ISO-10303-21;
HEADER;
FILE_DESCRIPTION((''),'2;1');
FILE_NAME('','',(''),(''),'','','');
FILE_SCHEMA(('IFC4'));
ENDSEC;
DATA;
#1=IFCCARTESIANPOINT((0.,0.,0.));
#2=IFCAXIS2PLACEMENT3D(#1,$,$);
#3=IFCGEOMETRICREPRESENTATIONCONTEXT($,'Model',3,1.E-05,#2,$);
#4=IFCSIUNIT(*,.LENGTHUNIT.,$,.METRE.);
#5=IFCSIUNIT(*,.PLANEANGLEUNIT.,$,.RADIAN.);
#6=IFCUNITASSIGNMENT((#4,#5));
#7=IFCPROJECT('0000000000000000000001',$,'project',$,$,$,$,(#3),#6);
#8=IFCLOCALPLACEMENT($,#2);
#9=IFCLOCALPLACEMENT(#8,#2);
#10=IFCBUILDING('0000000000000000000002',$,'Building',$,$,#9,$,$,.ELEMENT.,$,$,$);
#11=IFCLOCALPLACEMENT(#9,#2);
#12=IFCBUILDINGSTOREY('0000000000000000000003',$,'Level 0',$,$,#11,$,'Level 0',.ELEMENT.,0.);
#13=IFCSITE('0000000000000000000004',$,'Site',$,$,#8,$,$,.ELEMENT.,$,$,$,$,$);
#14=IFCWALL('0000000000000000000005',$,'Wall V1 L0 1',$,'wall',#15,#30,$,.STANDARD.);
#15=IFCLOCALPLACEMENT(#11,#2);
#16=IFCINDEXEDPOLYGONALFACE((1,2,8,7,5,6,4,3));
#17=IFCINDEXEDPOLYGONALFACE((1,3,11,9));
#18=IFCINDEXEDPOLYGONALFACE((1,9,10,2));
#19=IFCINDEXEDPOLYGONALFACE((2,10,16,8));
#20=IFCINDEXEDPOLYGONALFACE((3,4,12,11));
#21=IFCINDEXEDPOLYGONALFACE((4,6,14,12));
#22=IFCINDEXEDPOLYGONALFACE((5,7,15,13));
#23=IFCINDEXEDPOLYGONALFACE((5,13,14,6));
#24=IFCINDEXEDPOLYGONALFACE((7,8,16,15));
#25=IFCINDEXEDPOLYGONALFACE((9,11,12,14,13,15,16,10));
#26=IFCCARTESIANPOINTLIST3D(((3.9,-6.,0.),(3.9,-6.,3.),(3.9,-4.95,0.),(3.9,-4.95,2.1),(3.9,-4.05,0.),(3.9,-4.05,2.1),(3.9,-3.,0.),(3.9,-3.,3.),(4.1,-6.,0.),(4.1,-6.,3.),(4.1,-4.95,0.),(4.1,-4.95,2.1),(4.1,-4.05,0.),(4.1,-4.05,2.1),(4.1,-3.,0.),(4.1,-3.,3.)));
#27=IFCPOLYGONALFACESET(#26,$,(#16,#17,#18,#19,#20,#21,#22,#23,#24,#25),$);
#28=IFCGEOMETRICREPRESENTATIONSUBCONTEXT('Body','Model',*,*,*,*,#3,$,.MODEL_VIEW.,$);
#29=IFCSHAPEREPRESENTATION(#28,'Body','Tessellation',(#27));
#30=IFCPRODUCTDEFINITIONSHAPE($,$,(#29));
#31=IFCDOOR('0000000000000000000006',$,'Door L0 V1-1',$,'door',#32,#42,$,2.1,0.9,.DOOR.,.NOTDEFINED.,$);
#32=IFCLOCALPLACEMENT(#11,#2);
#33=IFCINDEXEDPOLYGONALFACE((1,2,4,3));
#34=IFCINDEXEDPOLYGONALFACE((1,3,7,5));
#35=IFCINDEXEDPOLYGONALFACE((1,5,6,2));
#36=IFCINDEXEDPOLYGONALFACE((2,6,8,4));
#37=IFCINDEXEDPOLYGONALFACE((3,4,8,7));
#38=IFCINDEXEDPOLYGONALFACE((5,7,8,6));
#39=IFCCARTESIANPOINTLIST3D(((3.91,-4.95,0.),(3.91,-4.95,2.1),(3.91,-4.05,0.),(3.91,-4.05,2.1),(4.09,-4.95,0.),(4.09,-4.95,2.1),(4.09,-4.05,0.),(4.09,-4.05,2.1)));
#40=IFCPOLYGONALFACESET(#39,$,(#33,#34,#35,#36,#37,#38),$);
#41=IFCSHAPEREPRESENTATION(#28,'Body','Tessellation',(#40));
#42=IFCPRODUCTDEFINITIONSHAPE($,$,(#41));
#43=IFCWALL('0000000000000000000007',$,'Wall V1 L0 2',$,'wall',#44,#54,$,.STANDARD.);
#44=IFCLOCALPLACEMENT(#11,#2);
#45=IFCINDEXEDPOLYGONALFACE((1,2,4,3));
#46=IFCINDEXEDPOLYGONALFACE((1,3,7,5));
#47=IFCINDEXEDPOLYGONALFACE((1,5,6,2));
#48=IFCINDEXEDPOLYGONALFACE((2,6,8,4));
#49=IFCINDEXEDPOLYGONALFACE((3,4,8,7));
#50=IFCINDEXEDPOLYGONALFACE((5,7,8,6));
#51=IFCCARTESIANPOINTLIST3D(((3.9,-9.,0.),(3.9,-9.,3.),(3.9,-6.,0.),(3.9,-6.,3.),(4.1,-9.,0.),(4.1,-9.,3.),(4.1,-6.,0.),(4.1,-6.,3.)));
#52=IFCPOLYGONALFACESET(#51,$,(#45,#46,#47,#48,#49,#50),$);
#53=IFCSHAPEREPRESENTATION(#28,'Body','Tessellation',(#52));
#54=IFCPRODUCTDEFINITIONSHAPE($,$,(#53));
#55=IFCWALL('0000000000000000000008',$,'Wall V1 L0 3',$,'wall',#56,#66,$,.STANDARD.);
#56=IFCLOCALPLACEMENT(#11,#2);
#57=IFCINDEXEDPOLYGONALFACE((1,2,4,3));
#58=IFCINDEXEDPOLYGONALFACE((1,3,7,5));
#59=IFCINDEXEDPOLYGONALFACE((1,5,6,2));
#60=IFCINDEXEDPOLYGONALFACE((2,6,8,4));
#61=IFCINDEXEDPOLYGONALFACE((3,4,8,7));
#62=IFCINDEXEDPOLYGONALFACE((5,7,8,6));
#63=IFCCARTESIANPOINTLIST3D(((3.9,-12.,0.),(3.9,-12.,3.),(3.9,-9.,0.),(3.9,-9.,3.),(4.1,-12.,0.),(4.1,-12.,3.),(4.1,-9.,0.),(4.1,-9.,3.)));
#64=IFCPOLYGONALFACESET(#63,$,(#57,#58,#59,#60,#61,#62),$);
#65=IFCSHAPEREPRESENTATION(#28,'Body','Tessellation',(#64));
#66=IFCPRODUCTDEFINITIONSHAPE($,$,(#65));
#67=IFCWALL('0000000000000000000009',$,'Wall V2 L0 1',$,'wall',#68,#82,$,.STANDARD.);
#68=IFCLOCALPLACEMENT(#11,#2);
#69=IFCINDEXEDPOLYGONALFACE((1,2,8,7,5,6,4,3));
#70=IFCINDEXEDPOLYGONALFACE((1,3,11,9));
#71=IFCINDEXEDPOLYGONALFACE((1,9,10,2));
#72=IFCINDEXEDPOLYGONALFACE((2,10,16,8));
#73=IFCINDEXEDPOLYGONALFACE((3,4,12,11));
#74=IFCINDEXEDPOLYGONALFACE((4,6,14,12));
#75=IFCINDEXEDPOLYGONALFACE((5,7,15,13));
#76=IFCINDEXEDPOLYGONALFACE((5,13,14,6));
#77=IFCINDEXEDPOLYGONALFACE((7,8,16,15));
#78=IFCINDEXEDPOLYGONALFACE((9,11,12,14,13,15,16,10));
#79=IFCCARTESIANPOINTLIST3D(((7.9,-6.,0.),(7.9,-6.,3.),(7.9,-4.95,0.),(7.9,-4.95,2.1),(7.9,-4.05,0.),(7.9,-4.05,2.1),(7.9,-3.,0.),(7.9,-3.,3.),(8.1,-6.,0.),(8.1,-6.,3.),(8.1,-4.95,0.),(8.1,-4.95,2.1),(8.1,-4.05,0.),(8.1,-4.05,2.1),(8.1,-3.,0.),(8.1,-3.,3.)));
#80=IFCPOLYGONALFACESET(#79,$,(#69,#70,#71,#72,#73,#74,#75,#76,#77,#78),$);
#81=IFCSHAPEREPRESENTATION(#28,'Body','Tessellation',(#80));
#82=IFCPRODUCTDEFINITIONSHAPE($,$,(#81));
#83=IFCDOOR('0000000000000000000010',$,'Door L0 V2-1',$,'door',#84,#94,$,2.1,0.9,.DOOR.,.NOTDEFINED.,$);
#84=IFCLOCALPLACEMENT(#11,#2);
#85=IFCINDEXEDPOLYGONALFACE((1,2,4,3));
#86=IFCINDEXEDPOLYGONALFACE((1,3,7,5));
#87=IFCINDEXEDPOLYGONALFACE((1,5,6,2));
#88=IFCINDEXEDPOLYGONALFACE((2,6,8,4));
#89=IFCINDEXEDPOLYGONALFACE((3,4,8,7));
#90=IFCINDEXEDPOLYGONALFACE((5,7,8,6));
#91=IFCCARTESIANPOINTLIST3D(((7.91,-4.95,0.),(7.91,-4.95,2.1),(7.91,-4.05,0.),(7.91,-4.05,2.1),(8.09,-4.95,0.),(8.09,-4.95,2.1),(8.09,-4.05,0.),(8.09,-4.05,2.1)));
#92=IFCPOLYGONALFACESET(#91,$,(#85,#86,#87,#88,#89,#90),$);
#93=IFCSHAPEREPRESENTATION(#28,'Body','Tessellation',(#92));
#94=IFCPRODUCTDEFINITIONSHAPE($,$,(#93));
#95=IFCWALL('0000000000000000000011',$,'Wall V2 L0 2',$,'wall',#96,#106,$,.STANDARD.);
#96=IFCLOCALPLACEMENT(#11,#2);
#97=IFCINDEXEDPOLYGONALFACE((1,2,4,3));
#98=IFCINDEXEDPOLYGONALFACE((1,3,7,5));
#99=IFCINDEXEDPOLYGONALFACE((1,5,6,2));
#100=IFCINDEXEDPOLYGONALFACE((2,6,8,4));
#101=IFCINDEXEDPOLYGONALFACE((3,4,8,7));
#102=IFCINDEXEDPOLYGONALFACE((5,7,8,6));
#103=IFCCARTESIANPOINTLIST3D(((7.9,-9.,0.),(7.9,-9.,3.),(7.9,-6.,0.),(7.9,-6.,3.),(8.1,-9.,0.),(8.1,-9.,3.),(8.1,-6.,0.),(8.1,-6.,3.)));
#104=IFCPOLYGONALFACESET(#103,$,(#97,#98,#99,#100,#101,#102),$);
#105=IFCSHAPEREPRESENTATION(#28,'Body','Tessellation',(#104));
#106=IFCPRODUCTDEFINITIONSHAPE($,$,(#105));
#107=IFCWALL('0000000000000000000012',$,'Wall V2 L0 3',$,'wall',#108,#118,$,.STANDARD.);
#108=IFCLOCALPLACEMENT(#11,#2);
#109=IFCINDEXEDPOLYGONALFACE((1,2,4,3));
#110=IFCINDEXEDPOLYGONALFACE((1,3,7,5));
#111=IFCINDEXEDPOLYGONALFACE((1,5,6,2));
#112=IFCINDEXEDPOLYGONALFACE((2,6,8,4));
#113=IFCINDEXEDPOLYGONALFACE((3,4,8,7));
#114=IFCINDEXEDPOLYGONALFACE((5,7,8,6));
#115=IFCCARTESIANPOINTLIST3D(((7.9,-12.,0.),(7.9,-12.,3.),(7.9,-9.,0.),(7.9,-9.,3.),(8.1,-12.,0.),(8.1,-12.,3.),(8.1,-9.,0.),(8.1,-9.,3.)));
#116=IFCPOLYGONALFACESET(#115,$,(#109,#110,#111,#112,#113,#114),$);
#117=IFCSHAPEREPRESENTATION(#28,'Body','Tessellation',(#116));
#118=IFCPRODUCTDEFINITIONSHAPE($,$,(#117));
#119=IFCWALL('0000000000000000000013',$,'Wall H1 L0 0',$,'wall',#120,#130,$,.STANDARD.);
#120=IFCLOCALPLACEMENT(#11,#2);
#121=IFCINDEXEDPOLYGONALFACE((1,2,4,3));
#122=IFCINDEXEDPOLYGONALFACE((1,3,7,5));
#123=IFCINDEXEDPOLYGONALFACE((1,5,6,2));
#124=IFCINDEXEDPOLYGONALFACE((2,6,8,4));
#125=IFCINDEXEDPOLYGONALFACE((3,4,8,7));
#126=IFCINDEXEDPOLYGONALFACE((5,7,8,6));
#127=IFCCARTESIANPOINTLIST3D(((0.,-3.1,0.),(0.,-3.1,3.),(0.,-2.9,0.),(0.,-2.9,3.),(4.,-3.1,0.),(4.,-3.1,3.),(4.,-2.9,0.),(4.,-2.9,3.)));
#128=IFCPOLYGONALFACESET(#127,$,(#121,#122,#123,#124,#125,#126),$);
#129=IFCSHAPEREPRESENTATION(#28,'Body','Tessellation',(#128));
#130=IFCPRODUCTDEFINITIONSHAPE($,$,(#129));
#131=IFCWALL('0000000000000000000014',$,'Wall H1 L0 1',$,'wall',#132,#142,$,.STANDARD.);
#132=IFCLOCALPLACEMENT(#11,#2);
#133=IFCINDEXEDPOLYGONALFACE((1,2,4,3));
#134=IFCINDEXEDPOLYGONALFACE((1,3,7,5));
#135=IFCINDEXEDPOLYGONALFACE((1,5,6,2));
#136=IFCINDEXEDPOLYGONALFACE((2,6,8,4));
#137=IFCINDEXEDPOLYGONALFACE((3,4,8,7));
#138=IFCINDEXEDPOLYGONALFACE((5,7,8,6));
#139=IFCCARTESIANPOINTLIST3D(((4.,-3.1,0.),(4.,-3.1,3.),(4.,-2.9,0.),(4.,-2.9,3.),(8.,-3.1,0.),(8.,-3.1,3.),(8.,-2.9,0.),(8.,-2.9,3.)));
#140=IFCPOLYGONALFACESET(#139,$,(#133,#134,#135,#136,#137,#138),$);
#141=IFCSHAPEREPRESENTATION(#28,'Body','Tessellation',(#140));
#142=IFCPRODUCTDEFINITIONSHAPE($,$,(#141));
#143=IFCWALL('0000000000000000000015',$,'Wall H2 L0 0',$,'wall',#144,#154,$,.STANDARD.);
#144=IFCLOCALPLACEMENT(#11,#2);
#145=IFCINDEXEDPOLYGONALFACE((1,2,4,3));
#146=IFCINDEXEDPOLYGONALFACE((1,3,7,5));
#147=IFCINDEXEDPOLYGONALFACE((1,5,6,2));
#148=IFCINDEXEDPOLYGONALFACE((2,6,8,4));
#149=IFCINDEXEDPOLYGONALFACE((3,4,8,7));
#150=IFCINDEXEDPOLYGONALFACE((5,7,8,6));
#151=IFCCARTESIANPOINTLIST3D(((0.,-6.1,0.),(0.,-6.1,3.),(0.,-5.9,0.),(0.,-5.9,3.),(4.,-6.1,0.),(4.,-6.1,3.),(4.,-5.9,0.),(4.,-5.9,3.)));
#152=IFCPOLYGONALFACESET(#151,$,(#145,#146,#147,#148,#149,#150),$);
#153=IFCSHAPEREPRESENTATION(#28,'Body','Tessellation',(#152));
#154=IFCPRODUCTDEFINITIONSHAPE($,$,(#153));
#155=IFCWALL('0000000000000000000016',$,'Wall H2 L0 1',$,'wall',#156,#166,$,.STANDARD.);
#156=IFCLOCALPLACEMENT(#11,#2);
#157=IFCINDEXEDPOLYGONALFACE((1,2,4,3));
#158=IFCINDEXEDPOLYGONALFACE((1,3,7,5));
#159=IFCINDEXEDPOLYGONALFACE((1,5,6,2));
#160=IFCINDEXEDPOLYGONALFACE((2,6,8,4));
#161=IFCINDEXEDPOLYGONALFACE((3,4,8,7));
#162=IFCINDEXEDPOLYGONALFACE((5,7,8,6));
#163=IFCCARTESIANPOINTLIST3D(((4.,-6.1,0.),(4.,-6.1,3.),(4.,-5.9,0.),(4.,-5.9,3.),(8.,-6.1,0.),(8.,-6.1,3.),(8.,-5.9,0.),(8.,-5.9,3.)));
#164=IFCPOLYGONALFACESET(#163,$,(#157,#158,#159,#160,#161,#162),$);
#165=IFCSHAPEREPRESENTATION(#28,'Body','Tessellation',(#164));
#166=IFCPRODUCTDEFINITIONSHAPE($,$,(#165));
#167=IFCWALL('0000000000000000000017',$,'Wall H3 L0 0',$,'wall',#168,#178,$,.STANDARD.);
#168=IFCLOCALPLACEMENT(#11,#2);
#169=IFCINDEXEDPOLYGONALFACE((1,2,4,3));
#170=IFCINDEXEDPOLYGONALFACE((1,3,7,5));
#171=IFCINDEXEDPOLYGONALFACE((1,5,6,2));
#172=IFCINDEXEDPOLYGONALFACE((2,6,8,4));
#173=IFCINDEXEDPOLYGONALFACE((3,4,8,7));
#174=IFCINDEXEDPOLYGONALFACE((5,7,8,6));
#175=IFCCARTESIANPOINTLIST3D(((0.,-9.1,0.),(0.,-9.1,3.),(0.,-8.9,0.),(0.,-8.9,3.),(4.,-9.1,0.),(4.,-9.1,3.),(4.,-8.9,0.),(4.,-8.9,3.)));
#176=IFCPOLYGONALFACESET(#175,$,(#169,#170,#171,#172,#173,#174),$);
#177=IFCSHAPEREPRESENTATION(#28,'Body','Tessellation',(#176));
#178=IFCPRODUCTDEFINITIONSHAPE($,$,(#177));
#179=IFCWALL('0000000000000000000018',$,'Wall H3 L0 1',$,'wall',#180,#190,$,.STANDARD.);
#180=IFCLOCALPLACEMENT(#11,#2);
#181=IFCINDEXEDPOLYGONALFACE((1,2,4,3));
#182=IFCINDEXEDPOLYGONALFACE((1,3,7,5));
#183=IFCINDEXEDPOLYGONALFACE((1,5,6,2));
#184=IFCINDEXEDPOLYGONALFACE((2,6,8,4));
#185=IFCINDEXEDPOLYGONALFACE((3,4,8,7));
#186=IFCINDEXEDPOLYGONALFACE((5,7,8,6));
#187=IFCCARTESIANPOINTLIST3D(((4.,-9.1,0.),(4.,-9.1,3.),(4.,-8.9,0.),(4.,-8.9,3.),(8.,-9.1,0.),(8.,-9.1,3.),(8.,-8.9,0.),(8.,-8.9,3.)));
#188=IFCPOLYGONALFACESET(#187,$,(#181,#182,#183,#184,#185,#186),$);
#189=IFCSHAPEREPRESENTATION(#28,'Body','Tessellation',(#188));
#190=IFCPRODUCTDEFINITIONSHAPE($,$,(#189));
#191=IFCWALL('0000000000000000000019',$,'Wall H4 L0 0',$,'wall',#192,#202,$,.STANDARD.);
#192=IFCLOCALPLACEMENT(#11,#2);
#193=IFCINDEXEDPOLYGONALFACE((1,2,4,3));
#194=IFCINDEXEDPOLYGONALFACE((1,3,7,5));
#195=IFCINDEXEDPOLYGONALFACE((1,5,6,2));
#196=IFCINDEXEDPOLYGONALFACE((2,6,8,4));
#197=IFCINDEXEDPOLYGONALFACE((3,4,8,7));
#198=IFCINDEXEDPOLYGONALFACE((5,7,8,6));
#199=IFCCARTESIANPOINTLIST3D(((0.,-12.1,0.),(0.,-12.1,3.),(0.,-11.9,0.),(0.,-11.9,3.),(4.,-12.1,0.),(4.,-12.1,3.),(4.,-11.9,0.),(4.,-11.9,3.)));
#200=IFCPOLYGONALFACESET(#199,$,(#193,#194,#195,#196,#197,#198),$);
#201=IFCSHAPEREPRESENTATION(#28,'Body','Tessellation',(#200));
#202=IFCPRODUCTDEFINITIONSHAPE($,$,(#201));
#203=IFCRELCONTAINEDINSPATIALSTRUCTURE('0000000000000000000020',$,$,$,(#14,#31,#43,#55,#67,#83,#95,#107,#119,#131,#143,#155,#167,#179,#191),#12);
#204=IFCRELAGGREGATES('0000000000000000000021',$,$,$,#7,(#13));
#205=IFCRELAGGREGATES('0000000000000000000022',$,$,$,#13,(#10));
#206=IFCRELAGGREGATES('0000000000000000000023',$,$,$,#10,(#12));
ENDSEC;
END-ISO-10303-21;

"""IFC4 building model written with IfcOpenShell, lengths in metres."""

from ifc_helpers import new_model, si_unit, frame, frame_2d, origin, origin_2d, place, context, subcontext, project, spatial, rectangle, extrude, element, fill, save


model = new_model("IFC4")

# Units and contexts
model_context = context("Model", 3, precision=1e-05, world=origin())
body_context = subcontext(model_context, "Body", "Model", "MODEL_VIEW")
ifc_project = project(units=[si_unit("LENGTHUNIT", "METRE"), si_unit("PLANEANGLEUNIT", "RADIAN")], contexts=[model_context])

# Site, building, storey
site_placement = place(None, origin())
site = spatial("IfcSite", under=ifc_project, at=site_placement, Name="Site", CompositionType="ELEMENT")
building_placement = place(site_placement, origin())
building = spatial("IfcBuilding", under=site, at=building_placement, Name="Building", CompositionType="ELEMENT")
storey_placement = place(building_placement, origin())
storey = spatial("IfcBuildingStorey", under=building, at=storey_placement, Name="Level 0", LongName="Level 0", CompositionType="ELEMENT", Elevation=0.0)

# Wall, opening, door
wall_1_placement = place(storey_placement, frame((4.0, -3.0, 0.0), z_axis=(0.0, 0.0, 1.0), x_axis=(0.0, -1.0, 0.0)))
wall_1 = element("IfcWall", 1, at=wall_1_placement, inside=storey, Name="Wall V1 L0 1", ObjectType="wall", PredefinedType="STANDARD", context=body_context, shape_type="SweptSolid", body=[
    extrude(rectangle(XDim=3.0, YDim=0.2, at=frame_2d((1.5, 0.0))), origin(), (0.0, 0.0, 1.0), 3.0),
])
opening_1_placement = place(storey_placement, frame((4.0, -4.5, 0.0), z_axis=(0.0, 0.0, 1.0), x_axis=(0.0, -1.0, 0.0)))
opening_1 = element("IfcOpeningElement", 2, at=opening_1_placement, cuts=wall_1, ObjectType="Opening", PredefinedType="OPENING", context=body_context, shape_type="SweptSolid", body=[
    extrude(rectangle(XDim=0.9, YDim=0.22, at=origin_2d()), origin(), (0.0, 0.0, 1.0), 2.1),
])
door_1_placement = place(storey_placement, frame((4.0, -4.5, 0.0), z_axis=(0.0, 0.0, 1.0), x_axis=(0.0, -1.0, 0.0)))
door_1 = element("IfcDoor", 3, at=door_1_placement, inside=storey, Name="Door L0 V1-1", ObjectType="door", OperationType="NOTDEFINED", OverallHeight=2.1, OverallWidth=0.9, PredefinedType="DOOR", context=body_context, shape_type="SweptSolid", body=[
    extrude(rectangle(XDim=0.9, YDim=0.18, at=origin_2d()), origin(), (0.0, 0.0, 1.0), 2.1),
])
fill(opening_1, door_1)

# Walls
for number, where, z_axis, x_axis, name in (
    (4, (4.0, -6.0, 0.0), (0.0, 0.0, 1.0), (0.0, -1.0, 0.0), "Wall V1 L0 2"),
    (5, (4.0, -9.0, 0.0), (0.0, 0.0, 1.0), (0.0, -1.0, 0.0), "Wall V1 L0 3"),
):
    element("IfcWall", number, at=place(storey_placement, frame(where, z_axis=z_axis, x_axis=x_axis)), inside=storey, Name=name, ObjectType="wall", PredefinedType="STANDARD", context=body_context, shape_type="SweptSolid", body=[
        extrude(rectangle(XDim=3.0, YDim=0.2, at=frame_2d((1.5, 0.0))), origin(), (0.0, 0.0, 1.0), 3.0),
    ])

# Wall, opening, door
wall_2_placement = place(storey_placement, frame((8.0, -3.0, 0.0), z_axis=(0.0, 0.0, 1.0), x_axis=(0.0, -1.0, 0.0)))
wall_2 = element("IfcWall", 6, at=wall_2_placement, inside=storey, Name="Wall V2 L0 1", ObjectType="wall", PredefinedType="STANDARD", context=body_context, shape_type="SweptSolid", body=[
    extrude(rectangle(XDim=3.0, YDim=0.2, at=frame_2d((1.5, 0.0))), origin(), (0.0, 0.0, 1.0), 3.0),
])
opening_2_placement = place(storey_placement, frame((8.0, -4.5, 0.0), z_axis=(0.0, 0.0, 1.0), x_axis=(0.0, -1.0, 0.0)))
opening_2 = element("IfcOpeningElement", 7, at=opening_2_placement, cuts=wall_2, ObjectType="Opening", PredefinedType="OPENING", context=body_context, shape_type="SweptSolid", body=[
    extrude(rectangle(XDim=0.9, YDim=0.22, at=origin_2d()), origin(), (0.0, 0.0, 1.0), 2.1),
])
door_2_placement = place(storey_placement, frame((8.0, -4.5, 0.0), z_axis=(0.0, 0.0, 1.0), x_axis=(0.0, -1.0, 0.0)))
door_2 = element("IfcDoor", 8, at=door_2_placement, inside=storey, Name="Door L0 V2-1", ObjectType="door", OperationType="NOTDEFINED", OverallHeight=2.1, OverallWidth=0.9, PredefinedType="DOOR", context=body_context, shape_type="SweptSolid", body=[
    extrude(rectangle(XDim=0.9, YDim=0.18, at=origin_2d()), origin(), (0.0, 0.0, 1.0), 2.1),
])
fill(opening_2, door_2)

# Walls
for number, where, z_axis, x_axis, name in (
    (9, (8.0, -6.0, 0.0), (0.0, 0.0, 1.0), (0.0, -1.0, 0.0), "Wall V2 L0 2"),
    (10, (8.0, -9.0, 0.0), (0.0, 0.0, 1.0), (0.0, -1.0, 0.0), "Wall V2 L0 3"),
):
    element("IfcWall", number, at=place(storey_placement, frame(where, z_axis=z_axis, x_axis=x_axis)), inside=storey, Name=name, ObjectType="wall", PredefinedType="STANDARD", context=body_context, shape_type="SweptSolid", body=[
        extrude(rectangle(XDim=3.0, YDim=0.2, at=frame_2d((1.5, 0.0))), origin(), (0.0, 0.0, 1.0), 3.0),
    ])
for number, where, z_axis, x_axis, name in (
    (11, (0.0, -3.0, 0.0), (0.0, 0.0, 1.0), (1.0, 0.0, 0.0), "Wall H1 L0 0"),
    (12, (4.0, -3.0, 0.0), (0.0, 0.0, 1.0), (1.0, 0.0, 0.0), "Wall H1 L0 1"),
    (13, (0.0, -6.0, 0.0), (0.0, 0.0, 1.0), (1.0, 0.0, 0.0), "Wall H2 L0 0"),
    (14, (4.0, -6.0, 0.0), (0.0, 0.0, 1.0), (1.0, 0.0, 0.0), "Wall H2 L0 1"),
    (15, (0.0, -9.0, 0.0), (0.0, 0.0, 1.0), (1.0, 0.0, 0.0), "Wall H3 L0 0"),
    (16, (4.0, -9.0, 0.0), (0.0, 0.0, 1.0), (1.0, 0.0, 0.0), "Wall H3 L0 1"),
    (17, (0.0, -12.0, 0.0), (0.0, 0.0, 1.0), (1.0, 0.0, 0.0), "Wall H4 L0 0"),
):
    element("IfcWall", number, at=place(storey_placement, frame(where, z_axis=z_axis, x_axis=x_axis)), inside=storey, Name=name, ObjectType="wall", PredefinedType="STANDARD", context=body_context, shape_type="SweptSolid", body=[
        extrude(rectangle(XDim=4.0, YDim=0.2, at=frame_2d((2.0, 0.0))), origin(), (0.0, 0.0, 1.0), 3.0),
    ])

save(model, "model.ifc")
